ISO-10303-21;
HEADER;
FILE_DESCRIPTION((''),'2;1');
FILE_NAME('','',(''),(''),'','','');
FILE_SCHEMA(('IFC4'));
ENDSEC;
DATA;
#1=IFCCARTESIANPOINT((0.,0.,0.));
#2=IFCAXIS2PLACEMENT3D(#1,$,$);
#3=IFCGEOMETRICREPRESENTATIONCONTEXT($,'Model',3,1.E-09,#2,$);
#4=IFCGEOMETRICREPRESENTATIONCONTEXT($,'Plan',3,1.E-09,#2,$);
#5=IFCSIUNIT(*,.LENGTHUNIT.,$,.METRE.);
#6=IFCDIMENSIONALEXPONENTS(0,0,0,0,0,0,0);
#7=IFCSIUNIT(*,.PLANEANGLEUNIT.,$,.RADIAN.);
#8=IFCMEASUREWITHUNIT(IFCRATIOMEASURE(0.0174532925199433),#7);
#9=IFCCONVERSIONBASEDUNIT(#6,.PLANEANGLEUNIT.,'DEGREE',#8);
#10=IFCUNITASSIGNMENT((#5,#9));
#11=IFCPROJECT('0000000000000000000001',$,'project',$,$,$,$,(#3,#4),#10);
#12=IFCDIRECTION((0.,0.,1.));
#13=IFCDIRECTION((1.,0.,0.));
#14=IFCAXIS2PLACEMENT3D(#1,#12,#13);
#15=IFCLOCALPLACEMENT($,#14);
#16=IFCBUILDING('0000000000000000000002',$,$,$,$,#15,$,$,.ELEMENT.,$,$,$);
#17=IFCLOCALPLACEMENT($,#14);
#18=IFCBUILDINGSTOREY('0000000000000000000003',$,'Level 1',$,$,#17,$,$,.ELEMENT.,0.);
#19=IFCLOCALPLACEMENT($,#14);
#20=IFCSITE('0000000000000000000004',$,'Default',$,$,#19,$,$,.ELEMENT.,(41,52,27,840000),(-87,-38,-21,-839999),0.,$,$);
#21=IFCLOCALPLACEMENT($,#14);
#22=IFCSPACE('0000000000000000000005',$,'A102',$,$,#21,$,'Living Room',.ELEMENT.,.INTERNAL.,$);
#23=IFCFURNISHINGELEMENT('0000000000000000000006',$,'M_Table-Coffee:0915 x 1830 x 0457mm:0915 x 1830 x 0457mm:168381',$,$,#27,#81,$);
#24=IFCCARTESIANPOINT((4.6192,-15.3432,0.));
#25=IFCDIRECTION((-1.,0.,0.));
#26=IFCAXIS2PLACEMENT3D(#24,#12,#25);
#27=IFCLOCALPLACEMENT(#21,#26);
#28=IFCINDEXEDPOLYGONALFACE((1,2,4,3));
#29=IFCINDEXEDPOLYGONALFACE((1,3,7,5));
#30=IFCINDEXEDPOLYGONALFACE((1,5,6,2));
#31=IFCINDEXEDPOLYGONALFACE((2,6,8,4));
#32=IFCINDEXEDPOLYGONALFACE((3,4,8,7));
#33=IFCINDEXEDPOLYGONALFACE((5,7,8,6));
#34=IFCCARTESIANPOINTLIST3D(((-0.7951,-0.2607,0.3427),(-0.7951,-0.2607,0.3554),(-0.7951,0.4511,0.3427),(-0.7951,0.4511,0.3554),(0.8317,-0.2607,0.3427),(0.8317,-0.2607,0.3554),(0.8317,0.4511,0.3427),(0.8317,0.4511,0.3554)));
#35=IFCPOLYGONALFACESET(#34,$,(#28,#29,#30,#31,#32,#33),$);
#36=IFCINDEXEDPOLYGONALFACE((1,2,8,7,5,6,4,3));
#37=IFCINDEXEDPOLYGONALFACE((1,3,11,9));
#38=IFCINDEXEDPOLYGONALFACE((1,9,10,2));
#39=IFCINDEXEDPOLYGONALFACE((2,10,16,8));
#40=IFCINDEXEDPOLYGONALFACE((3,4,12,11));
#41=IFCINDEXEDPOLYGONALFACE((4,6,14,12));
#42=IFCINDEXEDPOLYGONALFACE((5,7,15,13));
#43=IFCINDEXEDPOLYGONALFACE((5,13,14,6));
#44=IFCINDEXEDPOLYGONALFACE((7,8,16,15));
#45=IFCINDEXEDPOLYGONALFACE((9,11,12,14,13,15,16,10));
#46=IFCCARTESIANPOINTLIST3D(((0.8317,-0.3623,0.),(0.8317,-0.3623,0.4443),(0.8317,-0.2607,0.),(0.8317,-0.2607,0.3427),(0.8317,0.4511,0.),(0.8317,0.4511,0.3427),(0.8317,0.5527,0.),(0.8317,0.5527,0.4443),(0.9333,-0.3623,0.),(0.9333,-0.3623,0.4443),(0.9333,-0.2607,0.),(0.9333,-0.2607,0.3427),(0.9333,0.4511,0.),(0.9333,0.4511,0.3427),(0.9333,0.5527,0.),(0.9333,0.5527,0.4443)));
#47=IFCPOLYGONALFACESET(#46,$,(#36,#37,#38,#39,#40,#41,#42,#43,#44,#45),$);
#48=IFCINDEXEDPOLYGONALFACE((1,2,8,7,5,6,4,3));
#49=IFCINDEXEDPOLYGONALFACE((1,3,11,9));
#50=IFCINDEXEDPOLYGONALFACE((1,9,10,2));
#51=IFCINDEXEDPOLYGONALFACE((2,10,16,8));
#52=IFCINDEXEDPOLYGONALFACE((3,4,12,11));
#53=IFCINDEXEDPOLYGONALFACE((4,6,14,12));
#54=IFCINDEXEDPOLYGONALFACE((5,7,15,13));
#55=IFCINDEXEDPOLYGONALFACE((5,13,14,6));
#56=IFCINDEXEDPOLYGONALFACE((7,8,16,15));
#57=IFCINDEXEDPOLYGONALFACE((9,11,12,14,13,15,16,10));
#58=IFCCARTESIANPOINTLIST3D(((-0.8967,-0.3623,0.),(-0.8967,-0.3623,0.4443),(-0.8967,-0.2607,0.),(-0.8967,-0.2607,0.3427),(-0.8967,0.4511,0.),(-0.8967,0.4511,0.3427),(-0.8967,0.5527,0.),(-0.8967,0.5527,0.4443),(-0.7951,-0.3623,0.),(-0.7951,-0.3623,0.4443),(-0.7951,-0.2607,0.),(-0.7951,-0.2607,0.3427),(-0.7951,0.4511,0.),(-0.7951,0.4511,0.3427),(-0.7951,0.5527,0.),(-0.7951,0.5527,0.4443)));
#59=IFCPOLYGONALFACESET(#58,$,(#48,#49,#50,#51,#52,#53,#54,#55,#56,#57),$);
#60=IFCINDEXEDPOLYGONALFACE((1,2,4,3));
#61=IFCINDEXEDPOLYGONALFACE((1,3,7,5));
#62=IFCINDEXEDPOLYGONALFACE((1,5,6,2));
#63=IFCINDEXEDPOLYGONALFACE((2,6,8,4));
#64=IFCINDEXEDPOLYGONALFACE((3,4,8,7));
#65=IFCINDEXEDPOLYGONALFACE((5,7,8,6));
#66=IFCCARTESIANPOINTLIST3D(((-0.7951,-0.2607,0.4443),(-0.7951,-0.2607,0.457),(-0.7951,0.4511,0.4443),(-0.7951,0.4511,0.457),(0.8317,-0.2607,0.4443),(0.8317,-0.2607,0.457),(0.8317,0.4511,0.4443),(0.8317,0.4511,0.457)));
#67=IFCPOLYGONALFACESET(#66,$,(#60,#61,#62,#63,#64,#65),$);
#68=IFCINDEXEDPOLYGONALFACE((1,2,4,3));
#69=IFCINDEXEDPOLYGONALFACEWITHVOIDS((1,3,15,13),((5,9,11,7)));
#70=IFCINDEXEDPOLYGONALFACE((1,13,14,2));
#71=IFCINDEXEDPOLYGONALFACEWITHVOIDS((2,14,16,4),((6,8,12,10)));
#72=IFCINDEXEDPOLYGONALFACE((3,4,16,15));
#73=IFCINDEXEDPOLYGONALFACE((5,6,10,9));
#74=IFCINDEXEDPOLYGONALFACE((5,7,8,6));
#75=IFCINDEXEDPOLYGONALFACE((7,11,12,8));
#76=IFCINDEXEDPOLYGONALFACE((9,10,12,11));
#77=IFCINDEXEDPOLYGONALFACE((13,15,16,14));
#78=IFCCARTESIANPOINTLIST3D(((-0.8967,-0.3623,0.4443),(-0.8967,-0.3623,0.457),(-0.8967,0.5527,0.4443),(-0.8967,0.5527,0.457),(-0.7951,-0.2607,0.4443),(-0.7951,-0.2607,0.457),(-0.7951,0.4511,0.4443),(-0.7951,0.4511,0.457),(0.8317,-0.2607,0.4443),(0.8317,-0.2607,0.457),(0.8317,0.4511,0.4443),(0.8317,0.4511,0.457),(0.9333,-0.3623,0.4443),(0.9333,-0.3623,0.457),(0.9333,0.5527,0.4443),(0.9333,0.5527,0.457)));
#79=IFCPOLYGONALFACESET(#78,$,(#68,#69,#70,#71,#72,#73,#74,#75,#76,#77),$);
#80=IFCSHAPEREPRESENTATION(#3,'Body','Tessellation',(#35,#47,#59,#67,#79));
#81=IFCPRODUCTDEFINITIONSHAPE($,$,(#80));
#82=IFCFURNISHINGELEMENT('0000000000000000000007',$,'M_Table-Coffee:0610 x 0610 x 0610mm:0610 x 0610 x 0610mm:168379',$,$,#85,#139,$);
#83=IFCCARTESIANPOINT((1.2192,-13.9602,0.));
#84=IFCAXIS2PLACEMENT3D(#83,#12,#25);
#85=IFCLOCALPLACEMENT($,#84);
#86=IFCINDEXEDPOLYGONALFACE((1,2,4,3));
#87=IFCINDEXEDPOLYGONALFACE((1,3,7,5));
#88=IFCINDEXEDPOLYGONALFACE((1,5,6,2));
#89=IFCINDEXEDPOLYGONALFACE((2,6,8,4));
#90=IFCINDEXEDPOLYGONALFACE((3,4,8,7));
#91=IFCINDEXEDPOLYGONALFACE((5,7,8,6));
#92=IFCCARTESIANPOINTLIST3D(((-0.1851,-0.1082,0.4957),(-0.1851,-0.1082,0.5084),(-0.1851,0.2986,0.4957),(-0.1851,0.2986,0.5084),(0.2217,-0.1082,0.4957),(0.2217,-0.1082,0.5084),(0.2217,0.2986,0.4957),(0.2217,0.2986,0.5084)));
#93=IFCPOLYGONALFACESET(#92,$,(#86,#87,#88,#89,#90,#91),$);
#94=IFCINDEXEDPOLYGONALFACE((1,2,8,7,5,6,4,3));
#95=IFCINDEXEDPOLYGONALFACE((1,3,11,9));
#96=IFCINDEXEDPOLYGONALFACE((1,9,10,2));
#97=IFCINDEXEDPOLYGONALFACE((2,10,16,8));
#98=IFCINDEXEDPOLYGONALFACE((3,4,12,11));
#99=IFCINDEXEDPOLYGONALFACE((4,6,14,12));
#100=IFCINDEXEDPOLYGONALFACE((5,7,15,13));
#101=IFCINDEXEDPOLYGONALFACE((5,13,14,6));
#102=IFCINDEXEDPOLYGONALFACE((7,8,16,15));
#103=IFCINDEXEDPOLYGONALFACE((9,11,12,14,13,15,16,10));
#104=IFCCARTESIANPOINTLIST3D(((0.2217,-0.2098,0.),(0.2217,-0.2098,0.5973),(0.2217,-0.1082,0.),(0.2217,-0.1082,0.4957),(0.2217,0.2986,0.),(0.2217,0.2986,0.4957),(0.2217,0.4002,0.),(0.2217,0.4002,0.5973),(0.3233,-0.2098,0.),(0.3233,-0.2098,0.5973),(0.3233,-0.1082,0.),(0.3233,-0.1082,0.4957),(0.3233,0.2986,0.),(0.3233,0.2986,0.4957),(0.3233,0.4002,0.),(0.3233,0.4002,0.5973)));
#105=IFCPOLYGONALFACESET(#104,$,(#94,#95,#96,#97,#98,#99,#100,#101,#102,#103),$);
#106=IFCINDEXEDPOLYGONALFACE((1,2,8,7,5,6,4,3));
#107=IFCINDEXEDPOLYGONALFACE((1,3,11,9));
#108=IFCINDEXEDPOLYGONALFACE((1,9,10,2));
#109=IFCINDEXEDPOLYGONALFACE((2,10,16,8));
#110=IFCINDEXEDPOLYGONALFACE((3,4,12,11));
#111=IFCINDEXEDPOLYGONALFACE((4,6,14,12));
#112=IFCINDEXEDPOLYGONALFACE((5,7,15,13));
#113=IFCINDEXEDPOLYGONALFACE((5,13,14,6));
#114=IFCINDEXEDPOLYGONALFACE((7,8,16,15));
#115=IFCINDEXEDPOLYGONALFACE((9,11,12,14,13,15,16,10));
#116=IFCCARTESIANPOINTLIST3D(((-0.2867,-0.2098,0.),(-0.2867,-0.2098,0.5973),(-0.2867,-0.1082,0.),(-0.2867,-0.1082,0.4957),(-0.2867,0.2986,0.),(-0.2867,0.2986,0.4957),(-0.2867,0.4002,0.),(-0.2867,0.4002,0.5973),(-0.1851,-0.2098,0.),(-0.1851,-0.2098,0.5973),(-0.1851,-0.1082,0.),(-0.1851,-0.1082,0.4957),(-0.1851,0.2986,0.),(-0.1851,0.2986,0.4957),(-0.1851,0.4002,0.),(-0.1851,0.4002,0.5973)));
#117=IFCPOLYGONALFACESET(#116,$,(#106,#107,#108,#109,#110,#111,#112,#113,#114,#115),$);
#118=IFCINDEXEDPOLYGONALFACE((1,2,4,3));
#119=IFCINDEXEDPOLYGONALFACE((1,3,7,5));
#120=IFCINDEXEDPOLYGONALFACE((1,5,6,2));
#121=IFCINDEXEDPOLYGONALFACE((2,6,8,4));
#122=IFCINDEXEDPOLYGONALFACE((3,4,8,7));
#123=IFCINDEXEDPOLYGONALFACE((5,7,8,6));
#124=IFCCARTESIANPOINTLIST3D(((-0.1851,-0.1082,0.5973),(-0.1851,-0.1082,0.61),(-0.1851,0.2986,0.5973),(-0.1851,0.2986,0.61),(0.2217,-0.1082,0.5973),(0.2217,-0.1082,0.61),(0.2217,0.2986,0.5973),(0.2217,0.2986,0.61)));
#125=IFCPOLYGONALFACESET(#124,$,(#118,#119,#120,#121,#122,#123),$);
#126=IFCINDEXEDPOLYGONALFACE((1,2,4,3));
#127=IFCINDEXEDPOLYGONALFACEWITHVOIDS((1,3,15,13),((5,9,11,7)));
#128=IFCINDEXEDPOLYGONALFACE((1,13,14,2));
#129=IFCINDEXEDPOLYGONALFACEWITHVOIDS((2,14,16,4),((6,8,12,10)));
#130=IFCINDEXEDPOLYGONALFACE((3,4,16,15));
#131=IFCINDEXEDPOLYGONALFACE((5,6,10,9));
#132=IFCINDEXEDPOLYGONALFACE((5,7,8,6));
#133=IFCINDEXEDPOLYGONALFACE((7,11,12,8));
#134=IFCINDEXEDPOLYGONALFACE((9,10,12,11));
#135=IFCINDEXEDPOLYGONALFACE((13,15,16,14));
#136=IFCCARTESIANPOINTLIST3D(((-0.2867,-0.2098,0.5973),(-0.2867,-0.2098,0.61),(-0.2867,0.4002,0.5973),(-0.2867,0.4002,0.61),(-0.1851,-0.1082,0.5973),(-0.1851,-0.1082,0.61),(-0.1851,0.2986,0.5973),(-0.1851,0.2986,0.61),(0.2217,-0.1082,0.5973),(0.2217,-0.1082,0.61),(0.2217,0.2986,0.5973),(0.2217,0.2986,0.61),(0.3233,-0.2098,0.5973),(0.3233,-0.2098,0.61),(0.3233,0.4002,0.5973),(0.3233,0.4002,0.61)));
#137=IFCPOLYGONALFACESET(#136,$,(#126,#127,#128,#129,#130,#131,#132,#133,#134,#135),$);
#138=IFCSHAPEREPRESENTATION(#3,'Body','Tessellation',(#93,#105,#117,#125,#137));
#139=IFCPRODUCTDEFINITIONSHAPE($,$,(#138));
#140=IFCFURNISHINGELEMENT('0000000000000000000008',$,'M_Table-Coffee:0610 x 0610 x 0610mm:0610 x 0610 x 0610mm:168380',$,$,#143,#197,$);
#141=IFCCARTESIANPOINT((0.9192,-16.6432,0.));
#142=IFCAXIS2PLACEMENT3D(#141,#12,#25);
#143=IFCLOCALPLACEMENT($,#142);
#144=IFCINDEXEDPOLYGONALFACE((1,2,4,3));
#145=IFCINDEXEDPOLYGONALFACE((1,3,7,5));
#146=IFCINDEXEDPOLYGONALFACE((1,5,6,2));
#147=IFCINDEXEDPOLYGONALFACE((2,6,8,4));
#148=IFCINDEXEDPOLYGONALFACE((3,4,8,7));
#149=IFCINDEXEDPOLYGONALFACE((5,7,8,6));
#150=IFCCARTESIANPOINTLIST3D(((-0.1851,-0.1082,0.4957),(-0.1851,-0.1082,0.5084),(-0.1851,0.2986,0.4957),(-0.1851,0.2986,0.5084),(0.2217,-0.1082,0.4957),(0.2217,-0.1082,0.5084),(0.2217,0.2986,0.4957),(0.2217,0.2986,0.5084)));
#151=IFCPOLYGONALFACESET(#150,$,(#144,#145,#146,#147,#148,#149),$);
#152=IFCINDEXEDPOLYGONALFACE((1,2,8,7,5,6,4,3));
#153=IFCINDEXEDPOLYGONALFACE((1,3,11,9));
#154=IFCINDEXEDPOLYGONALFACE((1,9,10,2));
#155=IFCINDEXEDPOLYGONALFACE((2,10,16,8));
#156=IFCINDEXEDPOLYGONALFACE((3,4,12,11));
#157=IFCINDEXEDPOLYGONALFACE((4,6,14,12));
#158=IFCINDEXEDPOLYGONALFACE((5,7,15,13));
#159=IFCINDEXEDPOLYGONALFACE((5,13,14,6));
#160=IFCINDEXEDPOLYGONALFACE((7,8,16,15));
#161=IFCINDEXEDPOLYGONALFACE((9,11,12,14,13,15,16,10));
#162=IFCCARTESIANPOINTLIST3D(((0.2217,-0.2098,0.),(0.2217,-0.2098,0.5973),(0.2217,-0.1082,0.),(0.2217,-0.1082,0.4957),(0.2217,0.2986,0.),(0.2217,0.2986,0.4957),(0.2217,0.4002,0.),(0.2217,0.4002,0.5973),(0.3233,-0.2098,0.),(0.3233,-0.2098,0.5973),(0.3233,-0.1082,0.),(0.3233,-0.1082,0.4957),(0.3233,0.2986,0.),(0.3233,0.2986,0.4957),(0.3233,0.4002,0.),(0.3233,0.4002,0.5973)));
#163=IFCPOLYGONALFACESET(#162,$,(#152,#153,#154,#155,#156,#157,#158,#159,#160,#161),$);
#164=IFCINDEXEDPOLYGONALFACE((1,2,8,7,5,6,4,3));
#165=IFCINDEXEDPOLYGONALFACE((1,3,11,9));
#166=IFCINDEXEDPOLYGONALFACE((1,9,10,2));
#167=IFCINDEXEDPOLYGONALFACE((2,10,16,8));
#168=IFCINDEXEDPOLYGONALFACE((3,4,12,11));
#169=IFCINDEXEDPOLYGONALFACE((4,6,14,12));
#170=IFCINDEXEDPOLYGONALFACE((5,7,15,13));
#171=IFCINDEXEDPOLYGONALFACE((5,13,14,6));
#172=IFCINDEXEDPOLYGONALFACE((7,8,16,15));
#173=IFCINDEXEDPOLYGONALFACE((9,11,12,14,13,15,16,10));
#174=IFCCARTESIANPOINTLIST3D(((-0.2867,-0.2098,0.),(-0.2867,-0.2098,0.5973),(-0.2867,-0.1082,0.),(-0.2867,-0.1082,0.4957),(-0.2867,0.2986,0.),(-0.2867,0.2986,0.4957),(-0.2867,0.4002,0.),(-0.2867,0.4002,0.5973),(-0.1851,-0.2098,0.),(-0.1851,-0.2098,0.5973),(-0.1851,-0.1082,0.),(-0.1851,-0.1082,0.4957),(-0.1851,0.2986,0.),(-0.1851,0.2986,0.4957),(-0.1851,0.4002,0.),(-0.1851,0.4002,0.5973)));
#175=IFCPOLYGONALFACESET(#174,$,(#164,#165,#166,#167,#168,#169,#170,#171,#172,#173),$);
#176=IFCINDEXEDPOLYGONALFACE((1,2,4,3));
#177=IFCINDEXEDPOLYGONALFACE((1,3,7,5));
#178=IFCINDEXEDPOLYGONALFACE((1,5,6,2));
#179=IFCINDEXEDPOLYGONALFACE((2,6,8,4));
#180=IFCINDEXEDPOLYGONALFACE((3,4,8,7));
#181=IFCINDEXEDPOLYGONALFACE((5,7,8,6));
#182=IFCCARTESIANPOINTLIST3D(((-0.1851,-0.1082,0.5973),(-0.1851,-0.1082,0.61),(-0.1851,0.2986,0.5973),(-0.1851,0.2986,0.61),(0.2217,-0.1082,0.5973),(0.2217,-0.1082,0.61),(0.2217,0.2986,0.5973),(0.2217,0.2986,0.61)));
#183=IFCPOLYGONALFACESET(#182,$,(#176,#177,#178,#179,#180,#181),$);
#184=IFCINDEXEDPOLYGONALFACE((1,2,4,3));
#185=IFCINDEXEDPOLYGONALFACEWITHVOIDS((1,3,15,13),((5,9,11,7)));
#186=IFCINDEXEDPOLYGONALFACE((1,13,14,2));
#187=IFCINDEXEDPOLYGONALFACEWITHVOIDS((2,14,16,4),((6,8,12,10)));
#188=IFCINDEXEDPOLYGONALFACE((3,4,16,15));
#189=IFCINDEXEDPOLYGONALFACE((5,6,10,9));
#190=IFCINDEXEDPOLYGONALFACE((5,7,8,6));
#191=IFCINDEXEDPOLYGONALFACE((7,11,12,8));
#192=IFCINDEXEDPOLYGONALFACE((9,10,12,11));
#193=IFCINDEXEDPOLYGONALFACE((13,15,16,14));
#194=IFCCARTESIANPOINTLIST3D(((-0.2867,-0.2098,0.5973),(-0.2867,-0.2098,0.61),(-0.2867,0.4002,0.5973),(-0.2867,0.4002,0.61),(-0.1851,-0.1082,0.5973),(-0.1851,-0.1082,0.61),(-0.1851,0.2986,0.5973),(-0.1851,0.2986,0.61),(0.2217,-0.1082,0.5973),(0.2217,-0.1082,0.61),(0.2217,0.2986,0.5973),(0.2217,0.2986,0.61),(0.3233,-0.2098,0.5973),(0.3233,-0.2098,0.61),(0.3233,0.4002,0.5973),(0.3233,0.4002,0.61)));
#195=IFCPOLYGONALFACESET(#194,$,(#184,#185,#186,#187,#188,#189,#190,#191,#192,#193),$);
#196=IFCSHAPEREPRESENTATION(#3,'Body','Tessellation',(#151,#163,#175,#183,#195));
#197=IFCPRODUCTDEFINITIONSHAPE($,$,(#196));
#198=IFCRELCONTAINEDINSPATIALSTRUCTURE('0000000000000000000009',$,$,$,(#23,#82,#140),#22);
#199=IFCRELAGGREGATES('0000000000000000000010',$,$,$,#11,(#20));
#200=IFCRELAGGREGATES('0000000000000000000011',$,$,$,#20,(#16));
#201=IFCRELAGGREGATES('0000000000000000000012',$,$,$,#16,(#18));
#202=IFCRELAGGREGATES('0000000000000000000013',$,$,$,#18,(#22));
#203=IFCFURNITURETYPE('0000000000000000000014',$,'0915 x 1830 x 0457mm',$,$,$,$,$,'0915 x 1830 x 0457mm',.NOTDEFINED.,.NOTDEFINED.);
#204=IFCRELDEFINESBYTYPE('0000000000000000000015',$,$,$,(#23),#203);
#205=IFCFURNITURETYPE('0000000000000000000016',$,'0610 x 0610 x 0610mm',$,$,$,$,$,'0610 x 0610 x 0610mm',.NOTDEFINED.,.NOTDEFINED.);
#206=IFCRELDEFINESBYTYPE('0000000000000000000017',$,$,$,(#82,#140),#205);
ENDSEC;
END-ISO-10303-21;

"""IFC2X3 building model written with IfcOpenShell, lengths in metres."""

from ifc_helpers import new_model, entity, si_unit, converted_unit, frame, origin, origin_with_axes, origin_2d_with_axis, place, context, project, spatial, polyline, rectangle, outline, extrude, source, transform, mapped, type_object, type_shapes, element, save


model = new_model("IFC2X3")

# Units and contexts
model_context = context("Model", 3, precision=1e-09, world=origin())
plan_context = context("Plan", 3, precision=1e-09, world=origin())
ifc_project = project(units=[si_unit("LENGTHUNIT", "METRE"), converted_unit("PLANEANGLEUNIT", "DEGREE", entity("IfcRatioMeasure", 0.0174532925199433), si_unit("PLANEANGLEUNIT", "RADIAN"), dimensions=[0, 0, 0, 0, 0, 0, 0])], contexts=[model_context, plan_context])

# Site, building, storey, space
site_placement = place(None, origin_with_axes())
site = spatial("IfcSite", under=ifc_project, at=site_placement, Name="Default", CompositionType="ELEMENT", RefLatitude=(41, 52, 27, 840000), RefLongitude=(-87, -38, -21, -839999), RefElevation=0.0)
building_placement = place(None, origin_with_axes())
building = spatial("IfcBuilding", under=site, at=building_placement, CompositionType="ELEMENT")
storey_placement = place(None, origin_with_axes())
storey = spatial("IfcBuildingStorey", under=building, at=storey_placement, Name="Level 1", CompositionType="ELEMENT", Elevation=0.0)
space_placement = place(None, origin_with_axes())
space = spatial("IfcSpace", under=storey, at=space_placement, Name="A102", LongName="Living Room", CompositionType="ELEMENT", InteriorOrExteriorSpace="INTERNAL")

# Furnishing elements
furniture_type_1 = type_object("IfcFurnitureType", Name="0915 x 1830 x 0457mm", ElementType="0915 x 1830 x 0457mm", AssemblyPlace="NOTDEFINED")
shared_shape_1 = source(origin(), model_context, "Body", "SweptSolid", [
    extrude(rectangle(XDim=1.6268, YDim=0.7118, at=origin_2d_with_axis()), frame((0.0183, 0.0952, 0.3427), z_axis=(0.0, 0.0, 1.0), x_axis=(-1.0, 0.0, 0.0)), (0.0, 0.0, 1.0), 0.0127),
    extrude(outline(polyline([(-0.1967, -0.4575), (0.2475, -0.4575), (0.2475, 0.4575), (-0.1967, 0.4575), (-0.1967, 0.3559), (0.146, 0.3559), (0.146, -0.3559), (-0.1967, -0.3559), (-0.1967, -0.4575)])), frame((0.8317, 0.0952, 0.1967), z_axis=(1.0, 0.0, 0.0), x_axis=(0.0, 0.0, 1.0)), (0.0, 0.0, 1.0), 0.1016),
    extrude(outline(polyline([(-0.4575, -0.2476), (0.4575, -0.2476), (0.4575, 0.1968), (0.3559, 0.1968), (0.3559, -0.1459), (-0.3559, -0.1459), (-0.3559, 0.1968), (-0.4575, 0.1968), (-0.4575, -0.2476)])), frame((-0.8967, 0.0952, 0.1968), z_axis=(1.0, 0.0, 0.0), x_axis=(0.0, -1.0, 0.0)), (0.0, 0.0, 1.0), 0.1016),
    extrude(rectangle(XDim=1.6268, YDim=0.7118, at=origin_2d_with_axis()), frame((0.0183, 0.0952, 0.4443), z_axis=(0.0, 0.0, 1.0), x_axis=(-1.0, 0.0, 0.0)), (0.0, 0.0, 1.0), 0.0127),
    extrude(outline(polyline([(-0.915, -0.4575), (0.915, -0.4575), (0.915, 0.4575), (-0.915, 0.4575), (-0.915, -0.4575)]), holes=[polyline([(-0.8134, -0.3559), (-0.8134, 0.3559), (0.8134, 0.3559), (0.8134, -0.3559), (-0.8134, -0.3559)])]), frame((0.0183, 0.0952, 0.4443), z_axis=(0.0, 0.0, 1.0), x_axis=(-1.0, 0.0, 0.0)), (0.0, 0.0, 1.0), 0.0127),
])
type_shapes(furniture_type_1, [shared_shape_1])
furnishing_placement = place(space_placement, frame((4.6192, -15.3432, 0.0), z_axis=(0.0, 0.0, 1.0), x_axis=(-1.0, 0.0, 0.0)))
element("IfcFurnishingElement", 1, at=furnishing_placement, inside=space, type_object=furniture_type_1, Name="M_Table-Coffee:0915 x 1830 x 0457mm:0915 x 1830 x 0457mm:168381", context=model_context, shape_type="MappedRepresentation", body=[
    mapped(shared_shape_1, transform((0.0, 0.0, 0.0), scale=1.0)),
])
furniture_type_2 = type_object("IfcFurnitureType", Name="0610 x 0610 x 0610mm", ElementType="0610 x 0610 x 0610mm", AssemblyPlace="NOTDEFINED")
shared_shape_2 = source(origin(), model_context, "Body", "SweptSolid", [
    extrude(rectangle(XDim=0.4068, YDim=0.4068, at=origin_2d_with_axis()), frame((0.0183, 0.0952, 0.4957), z_axis=(0.0, 0.0, 1.0), x_axis=(-1.0, 0.0, 0.0)), (0.0, 0.0, 1.0), 0.0127),
    extrude(outline(polyline([(-0.2732, -0.305), (0.324, -0.305), (0.324, 0.305), (-0.2732, 0.305), (-0.2732, 0.2034), (0.2225, 0.2034), (0.2225, -0.2034), (-0.2732, -0.2034), (-0.2732, -0.305)])), frame((0.2217, 0.0952, 0.2732), z_axis=(1.0, 0.0, 0.0), x_axis=(0.0, 0.0, 1.0)), (0.0, 0.0, 1.0), 0.1016),
    extrude(outline(polyline([(-0.305, -0.3241), (0.305, -0.3241), (0.305, 0.2733), (0.2034, 0.2733), (0.2034, -0.2224), (-0.2034, -0.2224), (-0.2034, 0.2733), (-0.305, 0.2733), (-0.305, -0.3241)])), frame((-0.2867, 0.0952, 0.2733), z_axis=(1.0, 0.0, 0.0), x_axis=(0.0, -1.0, 0.0)), (0.0, 0.0, 1.0), 0.1016),
    extrude(rectangle(XDim=0.4068, YDim=0.4068, at=origin_2d_with_axis()), frame((0.0183, 0.0952, 0.5973), z_axis=(0.0, 0.0, 1.0), x_axis=(-1.0, 0.0, 0.0)), (0.0, 0.0, 1.0), 0.0127),
    extrude(outline(polyline([(-0.305, -0.305), (0.305, -0.305), (0.305, 0.305), (-0.305, 0.305), (-0.305, -0.305)]), holes=[polyline([(-0.2034, -0.2034), (-0.2034, 0.2034), (0.2034, 0.2034), (0.2034, -0.2034), (-0.2034, -0.2034)])]), frame((0.0183, 0.0952, 0.5973), z_axis=(0.0, 0.0, 1.0), x_axis=(-1.0, 0.0, 0.0)), (0.0, 0.0, 1.0), 0.0127),
])
type_shapes(furniture_type_2, [shared_shape_2])
for number, where, z_axis, x_axis, name in (
    (2, (1.2192, -13.9602, 0.0), (0.0, 0.0, 1.0), (-1.0, 0.0, 0.0), "M_Table-Coffee:0610 x 0610 x 0610mm:0610 x 0610 x 0610mm:168379"),
    (3, (0.9192, -16.6432, 0.0), (0.0, 0.0, 1.0), (-1.0, 0.0, 0.0), "M_Table-Coffee:0610 x 0610 x 0610mm:0610 x 0610 x 0610mm:168380"),
):
    element("IfcFurnishingElement", number, at=place(None, frame(where, z_axis=z_axis, x_axis=x_axis)), inside=space, type_object=furniture_type_2, Name=name, context=model_context, shape_type="MappedRepresentation", body=[
        mapped(shared_shape_2, transform((0.0, 0.0, 0.0), scale=1.0)),
    ])

save(model, "model.ifc")
